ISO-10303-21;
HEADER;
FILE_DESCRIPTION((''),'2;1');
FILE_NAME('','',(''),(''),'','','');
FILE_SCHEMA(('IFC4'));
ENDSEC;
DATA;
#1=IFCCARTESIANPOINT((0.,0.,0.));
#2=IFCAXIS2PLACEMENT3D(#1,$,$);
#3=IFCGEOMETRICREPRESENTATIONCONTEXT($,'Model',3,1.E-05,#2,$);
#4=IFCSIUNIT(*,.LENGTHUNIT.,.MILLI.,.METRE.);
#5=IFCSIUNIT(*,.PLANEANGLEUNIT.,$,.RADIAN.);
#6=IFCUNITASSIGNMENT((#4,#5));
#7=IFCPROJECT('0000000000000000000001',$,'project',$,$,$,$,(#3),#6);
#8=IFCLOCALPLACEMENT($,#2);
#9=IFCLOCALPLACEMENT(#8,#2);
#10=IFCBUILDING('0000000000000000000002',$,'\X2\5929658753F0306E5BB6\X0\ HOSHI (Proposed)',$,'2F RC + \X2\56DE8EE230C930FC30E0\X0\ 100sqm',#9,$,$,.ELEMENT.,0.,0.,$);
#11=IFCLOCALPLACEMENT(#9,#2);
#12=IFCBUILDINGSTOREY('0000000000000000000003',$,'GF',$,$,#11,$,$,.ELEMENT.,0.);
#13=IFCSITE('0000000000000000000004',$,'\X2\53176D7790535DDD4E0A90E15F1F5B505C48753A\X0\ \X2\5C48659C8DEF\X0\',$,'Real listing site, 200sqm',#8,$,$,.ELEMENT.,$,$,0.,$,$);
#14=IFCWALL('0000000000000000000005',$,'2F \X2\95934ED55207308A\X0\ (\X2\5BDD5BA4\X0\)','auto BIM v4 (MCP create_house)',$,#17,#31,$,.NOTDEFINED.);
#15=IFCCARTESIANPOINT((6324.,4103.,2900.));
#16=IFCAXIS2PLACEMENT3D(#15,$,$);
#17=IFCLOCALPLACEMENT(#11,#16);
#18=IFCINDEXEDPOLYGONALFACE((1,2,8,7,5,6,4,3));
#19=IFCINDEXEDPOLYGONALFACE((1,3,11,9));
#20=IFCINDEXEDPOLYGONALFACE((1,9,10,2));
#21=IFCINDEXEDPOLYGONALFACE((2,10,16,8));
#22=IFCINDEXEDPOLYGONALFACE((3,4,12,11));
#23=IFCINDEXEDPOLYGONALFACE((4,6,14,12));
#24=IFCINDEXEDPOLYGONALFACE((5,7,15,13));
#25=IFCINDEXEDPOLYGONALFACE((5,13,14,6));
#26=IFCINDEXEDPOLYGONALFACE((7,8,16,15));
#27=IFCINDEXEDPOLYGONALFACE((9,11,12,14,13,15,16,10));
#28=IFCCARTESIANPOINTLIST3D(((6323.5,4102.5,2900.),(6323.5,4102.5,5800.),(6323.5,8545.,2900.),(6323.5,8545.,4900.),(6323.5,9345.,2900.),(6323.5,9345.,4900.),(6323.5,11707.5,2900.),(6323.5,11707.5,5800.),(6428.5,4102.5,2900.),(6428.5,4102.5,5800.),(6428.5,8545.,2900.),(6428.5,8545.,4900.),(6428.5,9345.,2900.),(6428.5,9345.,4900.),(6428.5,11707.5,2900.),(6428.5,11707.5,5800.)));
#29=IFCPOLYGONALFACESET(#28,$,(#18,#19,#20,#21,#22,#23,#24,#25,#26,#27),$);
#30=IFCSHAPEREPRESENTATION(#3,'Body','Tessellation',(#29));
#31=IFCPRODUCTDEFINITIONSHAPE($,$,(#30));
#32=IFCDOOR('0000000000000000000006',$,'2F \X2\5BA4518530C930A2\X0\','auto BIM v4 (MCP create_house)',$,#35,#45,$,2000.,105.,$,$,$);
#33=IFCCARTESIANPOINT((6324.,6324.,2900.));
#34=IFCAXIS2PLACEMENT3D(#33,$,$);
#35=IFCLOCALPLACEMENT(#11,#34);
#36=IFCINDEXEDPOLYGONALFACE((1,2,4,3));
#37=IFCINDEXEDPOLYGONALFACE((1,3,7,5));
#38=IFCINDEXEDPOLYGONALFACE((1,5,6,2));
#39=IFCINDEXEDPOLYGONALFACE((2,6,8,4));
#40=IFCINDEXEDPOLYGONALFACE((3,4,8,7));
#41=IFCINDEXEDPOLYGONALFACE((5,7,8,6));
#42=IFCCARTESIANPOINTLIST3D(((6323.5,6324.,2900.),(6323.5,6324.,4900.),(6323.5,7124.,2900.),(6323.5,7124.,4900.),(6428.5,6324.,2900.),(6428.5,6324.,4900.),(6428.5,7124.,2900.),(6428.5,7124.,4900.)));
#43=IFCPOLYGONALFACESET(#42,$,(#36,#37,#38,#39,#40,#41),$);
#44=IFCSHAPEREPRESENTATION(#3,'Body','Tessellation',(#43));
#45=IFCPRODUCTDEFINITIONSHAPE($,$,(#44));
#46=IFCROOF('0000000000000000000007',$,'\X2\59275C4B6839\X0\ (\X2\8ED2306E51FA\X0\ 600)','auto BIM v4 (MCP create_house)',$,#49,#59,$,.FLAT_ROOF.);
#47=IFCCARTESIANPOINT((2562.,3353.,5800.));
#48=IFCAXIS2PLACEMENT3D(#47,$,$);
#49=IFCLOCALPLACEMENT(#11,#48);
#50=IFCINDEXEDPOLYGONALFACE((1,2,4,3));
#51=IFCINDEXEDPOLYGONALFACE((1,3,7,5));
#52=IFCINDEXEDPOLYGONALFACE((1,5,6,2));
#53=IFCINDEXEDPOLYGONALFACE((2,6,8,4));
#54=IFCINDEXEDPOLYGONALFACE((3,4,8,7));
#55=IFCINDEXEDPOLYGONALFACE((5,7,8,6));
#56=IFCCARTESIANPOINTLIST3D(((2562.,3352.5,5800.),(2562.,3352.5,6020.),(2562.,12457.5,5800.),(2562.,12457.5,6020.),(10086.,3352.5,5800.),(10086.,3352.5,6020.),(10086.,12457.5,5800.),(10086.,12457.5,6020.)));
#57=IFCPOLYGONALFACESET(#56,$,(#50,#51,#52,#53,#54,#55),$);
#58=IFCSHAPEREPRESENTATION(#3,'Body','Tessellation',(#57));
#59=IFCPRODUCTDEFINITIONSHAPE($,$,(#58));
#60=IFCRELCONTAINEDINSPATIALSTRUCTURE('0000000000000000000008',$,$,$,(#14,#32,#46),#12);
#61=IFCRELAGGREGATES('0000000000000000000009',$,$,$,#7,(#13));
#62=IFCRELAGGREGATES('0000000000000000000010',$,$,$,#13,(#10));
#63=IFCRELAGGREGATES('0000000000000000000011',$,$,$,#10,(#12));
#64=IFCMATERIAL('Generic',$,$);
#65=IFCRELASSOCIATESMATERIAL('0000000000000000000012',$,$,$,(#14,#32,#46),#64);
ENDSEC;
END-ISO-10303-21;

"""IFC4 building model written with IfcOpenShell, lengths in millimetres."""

from ifc_helpers import new_model, si_unit, frame, frame_2d, origin, place, context, project, spatial, rectangle, extrude, material, element, fill, save


model = new_model("IFC4")

# Units and contexts
model_context = context("Model", 3, precision=1e-05, world=origin())
ifc_project = project(units=[si_unit("LENGTHUNIT", "METRE", prefix="MILLI"), si_unit("PLANEANGLEUNIT", "RADIAN")], contexts=[model_context])

# Site, building, storey
site_placement = place(None, origin())
site = spatial("IfcSite", under=ifc_project, at=site_placement, Name="北海道川上郡弟子屈町 屈斜路", ObjectType="Real listing site, 200sqm", CompositionType="ELEMENT", RefElevation=0.0)
building_placement = place(site_placement, origin())
building = spatial("IfcBuilding", under=site, at=building_placement, Name="天文台の家 HOSHI (Proposed)", ObjectType="2F RC + 回転ドーム 100sqm", CompositionType="ELEMENT", ElevationOfRefHeight=0.0, ElevationOfTerrain=0.0)
storey_placement = place(building_placement, origin())
storey = spatial("IfcBuildingStorey", under=building, at=storey_placement, Name="GF", CompositionType="ELEMENT", Elevation=0.0)

# Shared definitions
ifc_material = material(Name="Generic")

# Wall, opening, door
wall_1_placement = place(storey_placement, frame((6324.0, 4103.0, 2900.0)))
wall_1 = element("IfcWall", 1, at=wall_1_placement, inside=storey, material=ifc_material, Name="2F 間仕切り (寝室)", Description="auto BIM v4 (MCP create_house)", PredefinedType="NOTDEFINED", context=model_context, shape_type="SweptSolid", body=[
    extrude(rectangle(XDim=105.0, YDim=7605.0, at=frame_2d((52.0, 3802.0))), frame((6324.0, 4103.0, 2900.0)), (0.0, 0.0, 1.0), 2900.0),
])
opening_1_placement = place(storey_placement, frame((6324.0, 6324.0, 2900.0)))
opening_1 = element("IfcOpeningElement", 2, at=opening_1_placement, cuts=wall_1, PredefinedType="NOTDEFINED", context=model_context, shape_type="SweptSolid", body=[
    extrude(rectangle(XDim=105.0, YDim=800.0, at=frame_2d((52.0, 400.0))), frame((6324.0, 6324.0, 2900.0)), (0.0, 0.0, 1.0), 2000.0),
])
door_1_placement = place(storey_placement, frame((6324.0, 6324.0, 2900.0)))
door_1 = element("IfcDoor", 3, at=door_1_placement, inside=storey, material=ifc_material, Name="2F 室内ドア", Description="auto BIM v4 (MCP create_house)", OverallHeight=2000.0, OverallWidth=105.0, context=model_context, shape_type="SweptSolid", body=[
    extrude(rectangle(XDim=105.0, YDim=800.0, at=frame_2d((52.0, 400.0))), frame((6324.0, 6324.0, 2900.0)), (0.0, 0.0, 1.0), 2000.0),
])
fill(opening_1, door_1)

# Roof
roof_placement = place(storey_placement, frame((2562.0, 3353.0, 5800.0)))
element("IfcRoof", 4, at=roof_placement, inside=storey, material=ifc_material, Name="大屋根 (軒の出 600)", Description="auto BIM v4 (MCP create_house)", PredefinedType="FLAT_ROOF", context=model_context, shape_type="SweptSolid", body=[
    extrude(rectangle(XDim=7524.0, YDim=9105.0, at=frame_2d((3762.0, 4552.0))), frame((2562.0, 3353.0, 5800.0)), (0.0, 0.0, 1.0), 220.0),
])

save(model, "model.ifc")
